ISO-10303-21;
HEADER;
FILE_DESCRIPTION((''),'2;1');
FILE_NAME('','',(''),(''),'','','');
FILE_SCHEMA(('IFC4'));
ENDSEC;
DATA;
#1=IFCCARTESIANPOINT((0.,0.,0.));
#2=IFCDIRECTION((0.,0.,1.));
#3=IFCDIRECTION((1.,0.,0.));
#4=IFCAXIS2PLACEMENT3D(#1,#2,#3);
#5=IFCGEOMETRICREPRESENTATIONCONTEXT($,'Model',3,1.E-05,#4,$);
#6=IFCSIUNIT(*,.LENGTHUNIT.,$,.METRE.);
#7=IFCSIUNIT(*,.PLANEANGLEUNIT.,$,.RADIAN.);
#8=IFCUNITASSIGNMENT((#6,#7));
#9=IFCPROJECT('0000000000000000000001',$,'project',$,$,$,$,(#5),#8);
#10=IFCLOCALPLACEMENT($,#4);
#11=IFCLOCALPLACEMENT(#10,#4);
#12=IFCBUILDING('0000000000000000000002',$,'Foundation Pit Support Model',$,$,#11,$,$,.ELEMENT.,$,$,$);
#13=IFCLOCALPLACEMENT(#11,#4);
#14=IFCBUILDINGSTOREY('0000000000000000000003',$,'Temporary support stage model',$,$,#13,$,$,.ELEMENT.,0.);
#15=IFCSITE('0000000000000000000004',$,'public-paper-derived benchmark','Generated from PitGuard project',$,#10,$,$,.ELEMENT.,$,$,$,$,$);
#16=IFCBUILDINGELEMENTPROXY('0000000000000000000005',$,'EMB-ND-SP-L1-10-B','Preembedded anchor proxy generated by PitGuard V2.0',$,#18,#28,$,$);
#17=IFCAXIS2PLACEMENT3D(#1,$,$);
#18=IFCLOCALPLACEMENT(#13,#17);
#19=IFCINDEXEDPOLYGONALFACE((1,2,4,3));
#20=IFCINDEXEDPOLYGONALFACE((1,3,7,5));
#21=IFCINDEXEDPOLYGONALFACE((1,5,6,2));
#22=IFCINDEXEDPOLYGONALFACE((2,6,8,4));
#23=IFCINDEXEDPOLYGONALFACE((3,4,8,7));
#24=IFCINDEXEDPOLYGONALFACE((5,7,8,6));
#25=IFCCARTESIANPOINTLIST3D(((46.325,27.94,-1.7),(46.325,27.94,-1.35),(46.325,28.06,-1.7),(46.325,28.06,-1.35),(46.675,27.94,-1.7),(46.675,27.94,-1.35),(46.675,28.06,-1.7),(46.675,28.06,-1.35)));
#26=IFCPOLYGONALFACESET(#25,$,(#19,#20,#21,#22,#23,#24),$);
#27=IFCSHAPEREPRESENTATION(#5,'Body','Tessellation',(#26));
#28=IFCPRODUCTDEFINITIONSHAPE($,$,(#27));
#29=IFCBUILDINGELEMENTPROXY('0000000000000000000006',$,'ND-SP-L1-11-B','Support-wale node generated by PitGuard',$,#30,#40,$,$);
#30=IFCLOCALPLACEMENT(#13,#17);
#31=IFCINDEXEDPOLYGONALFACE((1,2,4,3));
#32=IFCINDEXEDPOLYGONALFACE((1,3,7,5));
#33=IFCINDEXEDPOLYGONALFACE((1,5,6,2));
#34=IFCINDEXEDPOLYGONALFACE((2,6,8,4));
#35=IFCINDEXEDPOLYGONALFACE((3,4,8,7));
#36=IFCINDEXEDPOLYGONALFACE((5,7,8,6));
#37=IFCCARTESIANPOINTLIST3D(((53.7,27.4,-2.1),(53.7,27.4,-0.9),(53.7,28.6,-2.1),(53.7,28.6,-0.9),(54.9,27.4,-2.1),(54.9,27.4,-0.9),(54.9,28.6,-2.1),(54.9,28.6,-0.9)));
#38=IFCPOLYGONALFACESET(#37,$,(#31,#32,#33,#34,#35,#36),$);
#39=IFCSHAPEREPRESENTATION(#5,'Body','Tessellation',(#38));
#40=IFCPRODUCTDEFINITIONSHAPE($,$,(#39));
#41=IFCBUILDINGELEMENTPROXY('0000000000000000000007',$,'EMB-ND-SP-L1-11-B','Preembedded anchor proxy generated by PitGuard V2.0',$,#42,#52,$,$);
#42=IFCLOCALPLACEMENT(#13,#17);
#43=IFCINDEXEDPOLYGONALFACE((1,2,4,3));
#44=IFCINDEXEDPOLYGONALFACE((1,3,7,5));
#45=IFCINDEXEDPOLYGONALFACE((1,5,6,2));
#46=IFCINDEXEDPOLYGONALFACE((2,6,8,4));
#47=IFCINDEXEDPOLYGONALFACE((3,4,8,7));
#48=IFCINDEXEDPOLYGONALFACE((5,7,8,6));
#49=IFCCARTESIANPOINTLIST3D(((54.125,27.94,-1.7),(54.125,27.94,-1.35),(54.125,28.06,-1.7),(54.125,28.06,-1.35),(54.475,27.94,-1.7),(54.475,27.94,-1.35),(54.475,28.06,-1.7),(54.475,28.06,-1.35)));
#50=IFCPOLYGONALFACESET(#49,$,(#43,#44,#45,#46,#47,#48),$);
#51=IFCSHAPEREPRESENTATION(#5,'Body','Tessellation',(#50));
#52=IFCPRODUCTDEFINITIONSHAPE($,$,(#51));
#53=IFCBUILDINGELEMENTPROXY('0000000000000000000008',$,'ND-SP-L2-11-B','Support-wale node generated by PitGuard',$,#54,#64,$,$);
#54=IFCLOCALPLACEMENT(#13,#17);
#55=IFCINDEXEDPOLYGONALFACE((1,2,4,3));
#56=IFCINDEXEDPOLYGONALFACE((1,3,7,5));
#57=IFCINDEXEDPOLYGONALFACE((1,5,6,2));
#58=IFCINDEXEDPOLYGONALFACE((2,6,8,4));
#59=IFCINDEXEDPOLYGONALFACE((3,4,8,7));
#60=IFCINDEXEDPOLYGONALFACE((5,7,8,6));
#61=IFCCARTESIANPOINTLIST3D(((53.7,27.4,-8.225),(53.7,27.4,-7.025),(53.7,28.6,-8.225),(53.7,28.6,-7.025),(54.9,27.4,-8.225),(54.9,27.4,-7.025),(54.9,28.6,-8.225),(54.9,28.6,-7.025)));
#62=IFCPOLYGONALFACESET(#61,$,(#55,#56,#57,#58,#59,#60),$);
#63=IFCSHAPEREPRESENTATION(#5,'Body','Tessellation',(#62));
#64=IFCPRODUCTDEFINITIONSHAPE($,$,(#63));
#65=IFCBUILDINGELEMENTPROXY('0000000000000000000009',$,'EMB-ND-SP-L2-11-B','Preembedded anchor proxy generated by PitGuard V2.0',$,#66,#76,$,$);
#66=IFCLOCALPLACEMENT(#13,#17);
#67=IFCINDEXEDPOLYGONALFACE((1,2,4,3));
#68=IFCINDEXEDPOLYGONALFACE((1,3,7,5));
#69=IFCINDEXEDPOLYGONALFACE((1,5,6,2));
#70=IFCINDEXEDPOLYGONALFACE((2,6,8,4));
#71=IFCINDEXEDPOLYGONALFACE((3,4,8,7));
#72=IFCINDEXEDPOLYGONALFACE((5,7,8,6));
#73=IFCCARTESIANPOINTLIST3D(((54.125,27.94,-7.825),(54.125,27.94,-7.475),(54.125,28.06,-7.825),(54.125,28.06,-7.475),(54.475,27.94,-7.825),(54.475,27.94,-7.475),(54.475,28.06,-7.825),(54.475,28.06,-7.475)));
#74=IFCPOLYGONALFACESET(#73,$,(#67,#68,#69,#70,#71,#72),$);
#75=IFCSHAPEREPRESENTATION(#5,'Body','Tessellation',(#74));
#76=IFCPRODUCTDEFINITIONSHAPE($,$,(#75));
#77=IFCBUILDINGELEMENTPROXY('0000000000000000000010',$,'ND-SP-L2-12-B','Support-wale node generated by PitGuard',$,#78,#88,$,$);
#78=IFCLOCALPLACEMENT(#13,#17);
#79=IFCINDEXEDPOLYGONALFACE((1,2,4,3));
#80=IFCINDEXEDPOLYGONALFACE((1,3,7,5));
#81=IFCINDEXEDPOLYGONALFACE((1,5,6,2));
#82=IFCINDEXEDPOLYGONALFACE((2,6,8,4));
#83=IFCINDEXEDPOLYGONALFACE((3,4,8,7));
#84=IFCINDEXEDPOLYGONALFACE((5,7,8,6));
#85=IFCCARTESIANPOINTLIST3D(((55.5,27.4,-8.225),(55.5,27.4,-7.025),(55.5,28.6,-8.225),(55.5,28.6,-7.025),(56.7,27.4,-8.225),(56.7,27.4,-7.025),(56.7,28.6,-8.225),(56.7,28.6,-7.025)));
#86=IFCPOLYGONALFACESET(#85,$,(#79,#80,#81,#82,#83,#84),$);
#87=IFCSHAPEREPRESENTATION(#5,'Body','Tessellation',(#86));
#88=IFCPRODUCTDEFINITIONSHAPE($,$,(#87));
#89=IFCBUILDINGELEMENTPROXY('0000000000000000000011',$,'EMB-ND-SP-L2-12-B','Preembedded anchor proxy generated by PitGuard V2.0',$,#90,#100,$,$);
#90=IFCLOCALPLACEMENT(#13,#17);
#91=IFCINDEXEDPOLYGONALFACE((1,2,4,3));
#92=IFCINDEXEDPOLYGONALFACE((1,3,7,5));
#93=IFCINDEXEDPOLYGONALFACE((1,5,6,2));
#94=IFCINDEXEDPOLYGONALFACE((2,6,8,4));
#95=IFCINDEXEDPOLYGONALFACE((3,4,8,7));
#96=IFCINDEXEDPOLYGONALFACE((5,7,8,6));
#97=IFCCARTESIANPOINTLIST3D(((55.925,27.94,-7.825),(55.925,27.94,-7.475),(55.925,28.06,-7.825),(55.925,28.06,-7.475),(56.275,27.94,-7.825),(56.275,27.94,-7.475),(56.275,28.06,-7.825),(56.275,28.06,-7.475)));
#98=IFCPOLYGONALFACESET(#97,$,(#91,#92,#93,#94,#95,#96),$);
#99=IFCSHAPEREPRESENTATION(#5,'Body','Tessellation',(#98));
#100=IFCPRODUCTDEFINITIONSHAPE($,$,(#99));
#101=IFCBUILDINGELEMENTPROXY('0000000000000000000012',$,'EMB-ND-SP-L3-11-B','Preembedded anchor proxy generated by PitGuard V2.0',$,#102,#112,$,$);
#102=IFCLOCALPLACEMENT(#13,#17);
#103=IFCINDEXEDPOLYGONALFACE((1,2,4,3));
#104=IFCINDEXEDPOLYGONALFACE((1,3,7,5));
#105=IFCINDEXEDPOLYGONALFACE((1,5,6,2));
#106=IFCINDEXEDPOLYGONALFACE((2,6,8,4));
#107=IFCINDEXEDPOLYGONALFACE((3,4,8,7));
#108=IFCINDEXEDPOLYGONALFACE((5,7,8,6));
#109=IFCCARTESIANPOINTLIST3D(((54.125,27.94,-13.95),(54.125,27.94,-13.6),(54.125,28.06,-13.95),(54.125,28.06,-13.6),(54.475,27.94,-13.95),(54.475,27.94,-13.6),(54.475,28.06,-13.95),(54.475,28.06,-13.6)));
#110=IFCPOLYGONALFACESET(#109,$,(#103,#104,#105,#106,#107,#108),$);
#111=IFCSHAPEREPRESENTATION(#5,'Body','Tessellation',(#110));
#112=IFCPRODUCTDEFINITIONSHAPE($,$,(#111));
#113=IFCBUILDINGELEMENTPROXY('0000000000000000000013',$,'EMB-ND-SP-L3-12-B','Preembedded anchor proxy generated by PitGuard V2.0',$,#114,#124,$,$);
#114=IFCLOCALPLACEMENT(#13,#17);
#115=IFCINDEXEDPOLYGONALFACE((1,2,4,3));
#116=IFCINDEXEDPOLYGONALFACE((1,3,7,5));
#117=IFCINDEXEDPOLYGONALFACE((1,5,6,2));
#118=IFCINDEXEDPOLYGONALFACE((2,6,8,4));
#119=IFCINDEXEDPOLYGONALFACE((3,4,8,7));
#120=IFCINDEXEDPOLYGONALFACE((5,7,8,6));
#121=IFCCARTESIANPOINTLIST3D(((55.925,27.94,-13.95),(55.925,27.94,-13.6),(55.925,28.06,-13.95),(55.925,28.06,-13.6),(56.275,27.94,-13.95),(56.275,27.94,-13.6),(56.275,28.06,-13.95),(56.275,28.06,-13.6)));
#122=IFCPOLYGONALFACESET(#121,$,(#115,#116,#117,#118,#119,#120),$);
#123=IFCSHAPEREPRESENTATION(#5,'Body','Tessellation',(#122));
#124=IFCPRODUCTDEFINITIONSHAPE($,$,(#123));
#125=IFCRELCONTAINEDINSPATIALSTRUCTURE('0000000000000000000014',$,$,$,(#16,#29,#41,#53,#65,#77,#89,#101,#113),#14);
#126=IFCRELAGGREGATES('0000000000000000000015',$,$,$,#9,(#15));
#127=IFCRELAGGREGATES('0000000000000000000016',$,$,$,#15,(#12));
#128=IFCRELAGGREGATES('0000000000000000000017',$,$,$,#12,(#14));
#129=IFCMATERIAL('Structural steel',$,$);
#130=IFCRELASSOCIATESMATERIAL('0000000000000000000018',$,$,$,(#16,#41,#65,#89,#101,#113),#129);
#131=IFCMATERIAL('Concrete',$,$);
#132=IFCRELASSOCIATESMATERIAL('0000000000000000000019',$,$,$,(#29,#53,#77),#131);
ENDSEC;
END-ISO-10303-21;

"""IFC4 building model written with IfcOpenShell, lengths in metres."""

from ifc_helpers import new_model, si_unit, frame, origin_with_axes, origin_2d, place, context, project, spatial, rectangle, extrude, material, element, save


model = new_model("IFC4")

# Units and contexts
model_context = context("Model", 3, precision=1e-05, world=origin_with_axes())
ifc_project = project(units=[si_unit("LENGTHUNIT", "METRE"), si_unit("PLANEANGLEUNIT", "RADIAN")], contexts=[model_context])

# Site, building, storey
site_placement = place(None, origin_with_axes())
site = spatial("IfcSite", under=ifc_project, at=site_placement, Name="public-paper-derived benchmark", Description="Generated from PitGuard project", CompositionType="ELEMENT")
building_placement = place(site_placement, origin_with_axes())
building = spatial("IfcBuilding", under=site, at=building_placement, Name="Foundation Pit Support Model", CompositionType="ELEMENT")
storey_placement = place(building_placement, origin_with_axes())
storey = spatial("IfcBuildingStorey", under=building, at=storey_placement, Name="Temporary support stage model", CompositionType="ELEMENT", Elevation=0.0)

# Shared definitions
ifc_material_1 = material(Name="Concrete")

# Shared definitions
ifc_material_2 = material(Name="Structural steel")

# Building element proxies
proxy_1_placement = place(storey_placement, frame((46.5, 28.0, -1.7), z_axis=(0.0, 0.0, 1.0), x_axis=(1.0, 0.0, 0.0)))
element("IfcBuildingElementProxy", 1, at=proxy_1_placement, inside=storey, material=ifc_material_2, Name="EMB-ND-SP-L1-10-B", Description="Preembedded anchor proxy generated by PitGuard V2.0", context=model_context, shape_type="SweptSolid", body=[
    extrude(rectangle(XDim=0.35, YDim=0.12, at=origin_2d()), origin_with_axes(), (0.0, 0.0, 1.0), 0.35),
])
proxy_2_placement = place(storey_placement, frame((54.3, 28.0, -2.1), z_axis=(0.0, 0.0, 1.0), x_axis=(1.0, 0.0, 0.0)))
element("IfcBuildingElementProxy", 2, at=proxy_2_placement, inside=storey, material=ifc_material_1, Name="ND-SP-L1-11-B", Description="Support-wale node generated by PitGuard", context=model_context, shape_type="SweptSolid", body=[
    extrude(rectangle(XDim=1.2, YDim=1.2, at=origin_2d()), origin_with_axes(), (0.0, 0.0, 1.0), 1.2),
])
proxy_3_placement = place(storey_placement, frame((54.3, 28.0, -1.7), z_axis=(0.0, 0.0, 1.0), x_axis=(1.0, 0.0, 0.0)))
element("IfcBuildingElementProxy", 3, at=proxy_3_placement, inside=storey, material=ifc_material_2, Name="EMB-ND-SP-L1-11-B", Description="Preembedded anchor proxy generated by PitGuard V2.0", context=model_context, shape_type="SweptSolid", body=[
    extrude(rectangle(XDim=0.35, YDim=0.12, at=origin_2d()), origin_with_axes(), (0.0, 0.0, 1.0), 0.35),
])
proxy_4_placement = place(storey_placement, frame((54.3, 28.0, -8.225), z_axis=(0.0, 0.0, 1.0), x_axis=(1.0, 0.0, 0.0)))
element("IfcBuildingElementProxy", 4, at=proxy_4_placement, inside=storey, material=ifc_material_1, Name="ND-SP-L2-11-B", Description="Support-wale node generated by PitGuard", context=model_context, shape_type="SweptSolid", body=[
    extrude(rectangle(XDim=1.2, YDim=1.2, at=origin_2d()), origin_with_axes(), (0.0, 0.0, 1.0), 1.2),
])
proxy_5_placement = place(storey_placement, frame((54.3, 28.0, -7.825), z_axis=(0.0, 0.0, 1.0), x_axis=(1.0, 0.0, 0.0)))
element("IfcBuildingElementProxy", 5, at=proxy_5_placement, inside=storey, material=ifc_material_2, Name="EMB-ND-SP-L2-11-B", Description="Preembedded anchor proxy generated by PitGuard V2.0", context=model_context, shape_type="SweptSolid", body=[
    extrude(rectangle(XDim=0.35, YDim=0.12, at=origin_2d()), origin_with_axes(), (0.0, 0.0, 1.0), 0.35),
])
proxy_6_placement = place(storey_placement, frame((56.1, 28.0, -8.225), z_axis=(0.0, 0.0, 1.0), x_axis=(1.0, 0.0, 0.0)))
element("IfcBuildingElementProxy", 6, at=proxy_6_placement, inside=storey, material=ifc_material_1, Name="ND-SP-L2-12-B", Description="Support-wale node generated by PitGuard", context=model_context, shape_type="SweptSolid", body=[
    extrude(rectangle(XDim=1.2, YDim=1.2, at=origin_2d()), origin_with_axes(), (0.0, 0.0, 1.0), 1.2),
])
for number, where, z_axis, x_axis, name in (
    (7, (56.1, 28.0, -7.825), (0.0, 0.0, 1.0), (1.0, 0.0, 0.0), "EMB-ND-SP-L2-12-B"),
    (8, (54.3, 28.0, -13.95), (0.0, 0.0, 1.0), (1.0, 0.0, 0.0), "EMB-ND-SP-L3-11-B"),
    (9, (56.1, 28.0, -13.95), (0.0, 0.0, 1.0), (1.0, 0.0, 0.0), "EMB-ND-SP-L3-12-B"),
):
    element("IfcBuildingElementProxy", number, at=place(storey_placement, frame(where, z_axis=z_axis, x_axis=x_axis)), inside=storey, material=ifc_material_2, Name=name, Description="Preembedded anchor proxy generated by PitGuard V2.0", context=model_context, shape_type="SweptSolid", body=[
        extrude(rectangle(XDim=0.35, YDim=0.12, at=origin_2d()), origin_with_axes(), (0.0, 0.0, 1.0), 0.35),
    ])

save(model, "model.ifc")
